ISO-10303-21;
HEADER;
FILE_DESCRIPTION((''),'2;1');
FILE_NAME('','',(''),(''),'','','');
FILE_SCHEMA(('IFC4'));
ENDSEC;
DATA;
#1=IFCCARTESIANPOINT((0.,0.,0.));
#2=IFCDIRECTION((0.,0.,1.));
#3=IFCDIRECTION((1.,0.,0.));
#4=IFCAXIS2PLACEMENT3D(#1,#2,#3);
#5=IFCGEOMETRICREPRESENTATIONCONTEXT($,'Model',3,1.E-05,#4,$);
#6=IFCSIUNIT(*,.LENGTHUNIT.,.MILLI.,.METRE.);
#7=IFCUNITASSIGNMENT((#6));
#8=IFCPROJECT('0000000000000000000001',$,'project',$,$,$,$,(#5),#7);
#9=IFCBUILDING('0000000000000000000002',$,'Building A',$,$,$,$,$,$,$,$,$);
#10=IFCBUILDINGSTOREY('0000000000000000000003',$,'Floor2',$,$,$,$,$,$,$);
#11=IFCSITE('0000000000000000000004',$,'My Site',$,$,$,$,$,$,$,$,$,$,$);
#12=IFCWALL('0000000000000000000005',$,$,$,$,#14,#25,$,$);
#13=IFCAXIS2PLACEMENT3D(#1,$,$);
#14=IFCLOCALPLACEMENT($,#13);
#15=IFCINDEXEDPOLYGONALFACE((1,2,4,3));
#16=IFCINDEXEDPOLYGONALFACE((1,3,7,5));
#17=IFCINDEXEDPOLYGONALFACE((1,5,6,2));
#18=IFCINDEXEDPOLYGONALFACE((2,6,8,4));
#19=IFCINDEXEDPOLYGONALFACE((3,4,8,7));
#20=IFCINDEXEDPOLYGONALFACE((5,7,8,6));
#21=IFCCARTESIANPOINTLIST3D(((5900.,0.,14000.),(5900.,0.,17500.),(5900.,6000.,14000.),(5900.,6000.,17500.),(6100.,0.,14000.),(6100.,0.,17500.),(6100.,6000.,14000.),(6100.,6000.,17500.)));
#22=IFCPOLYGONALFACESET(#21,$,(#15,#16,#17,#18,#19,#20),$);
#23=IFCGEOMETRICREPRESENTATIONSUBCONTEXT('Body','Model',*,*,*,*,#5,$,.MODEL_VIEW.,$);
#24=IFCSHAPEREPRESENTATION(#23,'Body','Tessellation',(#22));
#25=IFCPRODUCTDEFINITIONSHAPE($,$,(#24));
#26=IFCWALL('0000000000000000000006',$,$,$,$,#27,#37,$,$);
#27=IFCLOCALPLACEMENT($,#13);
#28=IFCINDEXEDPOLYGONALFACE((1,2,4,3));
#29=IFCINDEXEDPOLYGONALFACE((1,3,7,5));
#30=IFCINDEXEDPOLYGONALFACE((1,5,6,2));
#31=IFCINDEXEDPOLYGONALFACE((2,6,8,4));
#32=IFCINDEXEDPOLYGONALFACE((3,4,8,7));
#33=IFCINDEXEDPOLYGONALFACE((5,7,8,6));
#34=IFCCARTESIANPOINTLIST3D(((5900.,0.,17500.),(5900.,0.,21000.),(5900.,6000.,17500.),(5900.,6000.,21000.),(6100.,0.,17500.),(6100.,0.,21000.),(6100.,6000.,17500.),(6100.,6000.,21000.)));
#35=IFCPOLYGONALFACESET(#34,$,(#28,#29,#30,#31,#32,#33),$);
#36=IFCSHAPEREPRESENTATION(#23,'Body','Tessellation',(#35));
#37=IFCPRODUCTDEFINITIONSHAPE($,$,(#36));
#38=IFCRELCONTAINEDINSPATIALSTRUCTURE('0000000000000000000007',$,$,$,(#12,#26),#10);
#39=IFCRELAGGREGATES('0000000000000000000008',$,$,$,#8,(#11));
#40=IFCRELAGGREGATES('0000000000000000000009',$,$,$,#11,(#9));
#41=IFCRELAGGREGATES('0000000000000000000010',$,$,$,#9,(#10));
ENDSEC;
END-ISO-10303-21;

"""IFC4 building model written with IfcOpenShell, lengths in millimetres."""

from ifc_helpers import new_model, si_unit, frame, origin_with_axes, place, context, subcontext, project, spatial, indexed_curve, outline, extrude, element, save


model = new_model("IFC4")

# Units and contexts
model_context = context("Model", 3, precision=1e-05, world=origin_with_axes())
body_context = subcontext(model_context, "Body", "Model", "MODEL_VIEW")
ifc_project = project(units=[si_unit("LENGTHUNIT", "METRE", prefix="MILLI")], contexts=[model_context])

# Site, building, storey
site = spatial("IfcSite", under=ifc_project, Name="My Site")
building = spatial("IfcBuilding", under=site, Name="Building A")
storey = spatial("IfcBuildingStorey", under=building, Name="Floor2")

# Walls
for number, where, z_axis, x_axis in (
    (1, (6100.0, 0.0, 14000.0), (0.0, 0.0, 1.0), (0.0, 1.0, 0.0)),
    (2, (6100.0, 0.0, 17500.0), (0.0, 0.0, 1.0), (0.0, 1.0, 0.0)),
):
    element("IfcWall", number, at=place(None, frame(where, z_axis=z_axis, x_axis=x_axis)), inside=storey, context=body_context, shape_type="SweptSolid", body=[
        extrude(outline(indexed_curve([(0.0, 0.0), (0.0, 200.0), (6000.0, 200.0), (6000.0, 0.0), (0.0, 0.0)], self_intersect=False)), origin_with_axes(), (0.0, 0.0, 1.0), 3500.0),
    ])

save(model, "model.ifc")
